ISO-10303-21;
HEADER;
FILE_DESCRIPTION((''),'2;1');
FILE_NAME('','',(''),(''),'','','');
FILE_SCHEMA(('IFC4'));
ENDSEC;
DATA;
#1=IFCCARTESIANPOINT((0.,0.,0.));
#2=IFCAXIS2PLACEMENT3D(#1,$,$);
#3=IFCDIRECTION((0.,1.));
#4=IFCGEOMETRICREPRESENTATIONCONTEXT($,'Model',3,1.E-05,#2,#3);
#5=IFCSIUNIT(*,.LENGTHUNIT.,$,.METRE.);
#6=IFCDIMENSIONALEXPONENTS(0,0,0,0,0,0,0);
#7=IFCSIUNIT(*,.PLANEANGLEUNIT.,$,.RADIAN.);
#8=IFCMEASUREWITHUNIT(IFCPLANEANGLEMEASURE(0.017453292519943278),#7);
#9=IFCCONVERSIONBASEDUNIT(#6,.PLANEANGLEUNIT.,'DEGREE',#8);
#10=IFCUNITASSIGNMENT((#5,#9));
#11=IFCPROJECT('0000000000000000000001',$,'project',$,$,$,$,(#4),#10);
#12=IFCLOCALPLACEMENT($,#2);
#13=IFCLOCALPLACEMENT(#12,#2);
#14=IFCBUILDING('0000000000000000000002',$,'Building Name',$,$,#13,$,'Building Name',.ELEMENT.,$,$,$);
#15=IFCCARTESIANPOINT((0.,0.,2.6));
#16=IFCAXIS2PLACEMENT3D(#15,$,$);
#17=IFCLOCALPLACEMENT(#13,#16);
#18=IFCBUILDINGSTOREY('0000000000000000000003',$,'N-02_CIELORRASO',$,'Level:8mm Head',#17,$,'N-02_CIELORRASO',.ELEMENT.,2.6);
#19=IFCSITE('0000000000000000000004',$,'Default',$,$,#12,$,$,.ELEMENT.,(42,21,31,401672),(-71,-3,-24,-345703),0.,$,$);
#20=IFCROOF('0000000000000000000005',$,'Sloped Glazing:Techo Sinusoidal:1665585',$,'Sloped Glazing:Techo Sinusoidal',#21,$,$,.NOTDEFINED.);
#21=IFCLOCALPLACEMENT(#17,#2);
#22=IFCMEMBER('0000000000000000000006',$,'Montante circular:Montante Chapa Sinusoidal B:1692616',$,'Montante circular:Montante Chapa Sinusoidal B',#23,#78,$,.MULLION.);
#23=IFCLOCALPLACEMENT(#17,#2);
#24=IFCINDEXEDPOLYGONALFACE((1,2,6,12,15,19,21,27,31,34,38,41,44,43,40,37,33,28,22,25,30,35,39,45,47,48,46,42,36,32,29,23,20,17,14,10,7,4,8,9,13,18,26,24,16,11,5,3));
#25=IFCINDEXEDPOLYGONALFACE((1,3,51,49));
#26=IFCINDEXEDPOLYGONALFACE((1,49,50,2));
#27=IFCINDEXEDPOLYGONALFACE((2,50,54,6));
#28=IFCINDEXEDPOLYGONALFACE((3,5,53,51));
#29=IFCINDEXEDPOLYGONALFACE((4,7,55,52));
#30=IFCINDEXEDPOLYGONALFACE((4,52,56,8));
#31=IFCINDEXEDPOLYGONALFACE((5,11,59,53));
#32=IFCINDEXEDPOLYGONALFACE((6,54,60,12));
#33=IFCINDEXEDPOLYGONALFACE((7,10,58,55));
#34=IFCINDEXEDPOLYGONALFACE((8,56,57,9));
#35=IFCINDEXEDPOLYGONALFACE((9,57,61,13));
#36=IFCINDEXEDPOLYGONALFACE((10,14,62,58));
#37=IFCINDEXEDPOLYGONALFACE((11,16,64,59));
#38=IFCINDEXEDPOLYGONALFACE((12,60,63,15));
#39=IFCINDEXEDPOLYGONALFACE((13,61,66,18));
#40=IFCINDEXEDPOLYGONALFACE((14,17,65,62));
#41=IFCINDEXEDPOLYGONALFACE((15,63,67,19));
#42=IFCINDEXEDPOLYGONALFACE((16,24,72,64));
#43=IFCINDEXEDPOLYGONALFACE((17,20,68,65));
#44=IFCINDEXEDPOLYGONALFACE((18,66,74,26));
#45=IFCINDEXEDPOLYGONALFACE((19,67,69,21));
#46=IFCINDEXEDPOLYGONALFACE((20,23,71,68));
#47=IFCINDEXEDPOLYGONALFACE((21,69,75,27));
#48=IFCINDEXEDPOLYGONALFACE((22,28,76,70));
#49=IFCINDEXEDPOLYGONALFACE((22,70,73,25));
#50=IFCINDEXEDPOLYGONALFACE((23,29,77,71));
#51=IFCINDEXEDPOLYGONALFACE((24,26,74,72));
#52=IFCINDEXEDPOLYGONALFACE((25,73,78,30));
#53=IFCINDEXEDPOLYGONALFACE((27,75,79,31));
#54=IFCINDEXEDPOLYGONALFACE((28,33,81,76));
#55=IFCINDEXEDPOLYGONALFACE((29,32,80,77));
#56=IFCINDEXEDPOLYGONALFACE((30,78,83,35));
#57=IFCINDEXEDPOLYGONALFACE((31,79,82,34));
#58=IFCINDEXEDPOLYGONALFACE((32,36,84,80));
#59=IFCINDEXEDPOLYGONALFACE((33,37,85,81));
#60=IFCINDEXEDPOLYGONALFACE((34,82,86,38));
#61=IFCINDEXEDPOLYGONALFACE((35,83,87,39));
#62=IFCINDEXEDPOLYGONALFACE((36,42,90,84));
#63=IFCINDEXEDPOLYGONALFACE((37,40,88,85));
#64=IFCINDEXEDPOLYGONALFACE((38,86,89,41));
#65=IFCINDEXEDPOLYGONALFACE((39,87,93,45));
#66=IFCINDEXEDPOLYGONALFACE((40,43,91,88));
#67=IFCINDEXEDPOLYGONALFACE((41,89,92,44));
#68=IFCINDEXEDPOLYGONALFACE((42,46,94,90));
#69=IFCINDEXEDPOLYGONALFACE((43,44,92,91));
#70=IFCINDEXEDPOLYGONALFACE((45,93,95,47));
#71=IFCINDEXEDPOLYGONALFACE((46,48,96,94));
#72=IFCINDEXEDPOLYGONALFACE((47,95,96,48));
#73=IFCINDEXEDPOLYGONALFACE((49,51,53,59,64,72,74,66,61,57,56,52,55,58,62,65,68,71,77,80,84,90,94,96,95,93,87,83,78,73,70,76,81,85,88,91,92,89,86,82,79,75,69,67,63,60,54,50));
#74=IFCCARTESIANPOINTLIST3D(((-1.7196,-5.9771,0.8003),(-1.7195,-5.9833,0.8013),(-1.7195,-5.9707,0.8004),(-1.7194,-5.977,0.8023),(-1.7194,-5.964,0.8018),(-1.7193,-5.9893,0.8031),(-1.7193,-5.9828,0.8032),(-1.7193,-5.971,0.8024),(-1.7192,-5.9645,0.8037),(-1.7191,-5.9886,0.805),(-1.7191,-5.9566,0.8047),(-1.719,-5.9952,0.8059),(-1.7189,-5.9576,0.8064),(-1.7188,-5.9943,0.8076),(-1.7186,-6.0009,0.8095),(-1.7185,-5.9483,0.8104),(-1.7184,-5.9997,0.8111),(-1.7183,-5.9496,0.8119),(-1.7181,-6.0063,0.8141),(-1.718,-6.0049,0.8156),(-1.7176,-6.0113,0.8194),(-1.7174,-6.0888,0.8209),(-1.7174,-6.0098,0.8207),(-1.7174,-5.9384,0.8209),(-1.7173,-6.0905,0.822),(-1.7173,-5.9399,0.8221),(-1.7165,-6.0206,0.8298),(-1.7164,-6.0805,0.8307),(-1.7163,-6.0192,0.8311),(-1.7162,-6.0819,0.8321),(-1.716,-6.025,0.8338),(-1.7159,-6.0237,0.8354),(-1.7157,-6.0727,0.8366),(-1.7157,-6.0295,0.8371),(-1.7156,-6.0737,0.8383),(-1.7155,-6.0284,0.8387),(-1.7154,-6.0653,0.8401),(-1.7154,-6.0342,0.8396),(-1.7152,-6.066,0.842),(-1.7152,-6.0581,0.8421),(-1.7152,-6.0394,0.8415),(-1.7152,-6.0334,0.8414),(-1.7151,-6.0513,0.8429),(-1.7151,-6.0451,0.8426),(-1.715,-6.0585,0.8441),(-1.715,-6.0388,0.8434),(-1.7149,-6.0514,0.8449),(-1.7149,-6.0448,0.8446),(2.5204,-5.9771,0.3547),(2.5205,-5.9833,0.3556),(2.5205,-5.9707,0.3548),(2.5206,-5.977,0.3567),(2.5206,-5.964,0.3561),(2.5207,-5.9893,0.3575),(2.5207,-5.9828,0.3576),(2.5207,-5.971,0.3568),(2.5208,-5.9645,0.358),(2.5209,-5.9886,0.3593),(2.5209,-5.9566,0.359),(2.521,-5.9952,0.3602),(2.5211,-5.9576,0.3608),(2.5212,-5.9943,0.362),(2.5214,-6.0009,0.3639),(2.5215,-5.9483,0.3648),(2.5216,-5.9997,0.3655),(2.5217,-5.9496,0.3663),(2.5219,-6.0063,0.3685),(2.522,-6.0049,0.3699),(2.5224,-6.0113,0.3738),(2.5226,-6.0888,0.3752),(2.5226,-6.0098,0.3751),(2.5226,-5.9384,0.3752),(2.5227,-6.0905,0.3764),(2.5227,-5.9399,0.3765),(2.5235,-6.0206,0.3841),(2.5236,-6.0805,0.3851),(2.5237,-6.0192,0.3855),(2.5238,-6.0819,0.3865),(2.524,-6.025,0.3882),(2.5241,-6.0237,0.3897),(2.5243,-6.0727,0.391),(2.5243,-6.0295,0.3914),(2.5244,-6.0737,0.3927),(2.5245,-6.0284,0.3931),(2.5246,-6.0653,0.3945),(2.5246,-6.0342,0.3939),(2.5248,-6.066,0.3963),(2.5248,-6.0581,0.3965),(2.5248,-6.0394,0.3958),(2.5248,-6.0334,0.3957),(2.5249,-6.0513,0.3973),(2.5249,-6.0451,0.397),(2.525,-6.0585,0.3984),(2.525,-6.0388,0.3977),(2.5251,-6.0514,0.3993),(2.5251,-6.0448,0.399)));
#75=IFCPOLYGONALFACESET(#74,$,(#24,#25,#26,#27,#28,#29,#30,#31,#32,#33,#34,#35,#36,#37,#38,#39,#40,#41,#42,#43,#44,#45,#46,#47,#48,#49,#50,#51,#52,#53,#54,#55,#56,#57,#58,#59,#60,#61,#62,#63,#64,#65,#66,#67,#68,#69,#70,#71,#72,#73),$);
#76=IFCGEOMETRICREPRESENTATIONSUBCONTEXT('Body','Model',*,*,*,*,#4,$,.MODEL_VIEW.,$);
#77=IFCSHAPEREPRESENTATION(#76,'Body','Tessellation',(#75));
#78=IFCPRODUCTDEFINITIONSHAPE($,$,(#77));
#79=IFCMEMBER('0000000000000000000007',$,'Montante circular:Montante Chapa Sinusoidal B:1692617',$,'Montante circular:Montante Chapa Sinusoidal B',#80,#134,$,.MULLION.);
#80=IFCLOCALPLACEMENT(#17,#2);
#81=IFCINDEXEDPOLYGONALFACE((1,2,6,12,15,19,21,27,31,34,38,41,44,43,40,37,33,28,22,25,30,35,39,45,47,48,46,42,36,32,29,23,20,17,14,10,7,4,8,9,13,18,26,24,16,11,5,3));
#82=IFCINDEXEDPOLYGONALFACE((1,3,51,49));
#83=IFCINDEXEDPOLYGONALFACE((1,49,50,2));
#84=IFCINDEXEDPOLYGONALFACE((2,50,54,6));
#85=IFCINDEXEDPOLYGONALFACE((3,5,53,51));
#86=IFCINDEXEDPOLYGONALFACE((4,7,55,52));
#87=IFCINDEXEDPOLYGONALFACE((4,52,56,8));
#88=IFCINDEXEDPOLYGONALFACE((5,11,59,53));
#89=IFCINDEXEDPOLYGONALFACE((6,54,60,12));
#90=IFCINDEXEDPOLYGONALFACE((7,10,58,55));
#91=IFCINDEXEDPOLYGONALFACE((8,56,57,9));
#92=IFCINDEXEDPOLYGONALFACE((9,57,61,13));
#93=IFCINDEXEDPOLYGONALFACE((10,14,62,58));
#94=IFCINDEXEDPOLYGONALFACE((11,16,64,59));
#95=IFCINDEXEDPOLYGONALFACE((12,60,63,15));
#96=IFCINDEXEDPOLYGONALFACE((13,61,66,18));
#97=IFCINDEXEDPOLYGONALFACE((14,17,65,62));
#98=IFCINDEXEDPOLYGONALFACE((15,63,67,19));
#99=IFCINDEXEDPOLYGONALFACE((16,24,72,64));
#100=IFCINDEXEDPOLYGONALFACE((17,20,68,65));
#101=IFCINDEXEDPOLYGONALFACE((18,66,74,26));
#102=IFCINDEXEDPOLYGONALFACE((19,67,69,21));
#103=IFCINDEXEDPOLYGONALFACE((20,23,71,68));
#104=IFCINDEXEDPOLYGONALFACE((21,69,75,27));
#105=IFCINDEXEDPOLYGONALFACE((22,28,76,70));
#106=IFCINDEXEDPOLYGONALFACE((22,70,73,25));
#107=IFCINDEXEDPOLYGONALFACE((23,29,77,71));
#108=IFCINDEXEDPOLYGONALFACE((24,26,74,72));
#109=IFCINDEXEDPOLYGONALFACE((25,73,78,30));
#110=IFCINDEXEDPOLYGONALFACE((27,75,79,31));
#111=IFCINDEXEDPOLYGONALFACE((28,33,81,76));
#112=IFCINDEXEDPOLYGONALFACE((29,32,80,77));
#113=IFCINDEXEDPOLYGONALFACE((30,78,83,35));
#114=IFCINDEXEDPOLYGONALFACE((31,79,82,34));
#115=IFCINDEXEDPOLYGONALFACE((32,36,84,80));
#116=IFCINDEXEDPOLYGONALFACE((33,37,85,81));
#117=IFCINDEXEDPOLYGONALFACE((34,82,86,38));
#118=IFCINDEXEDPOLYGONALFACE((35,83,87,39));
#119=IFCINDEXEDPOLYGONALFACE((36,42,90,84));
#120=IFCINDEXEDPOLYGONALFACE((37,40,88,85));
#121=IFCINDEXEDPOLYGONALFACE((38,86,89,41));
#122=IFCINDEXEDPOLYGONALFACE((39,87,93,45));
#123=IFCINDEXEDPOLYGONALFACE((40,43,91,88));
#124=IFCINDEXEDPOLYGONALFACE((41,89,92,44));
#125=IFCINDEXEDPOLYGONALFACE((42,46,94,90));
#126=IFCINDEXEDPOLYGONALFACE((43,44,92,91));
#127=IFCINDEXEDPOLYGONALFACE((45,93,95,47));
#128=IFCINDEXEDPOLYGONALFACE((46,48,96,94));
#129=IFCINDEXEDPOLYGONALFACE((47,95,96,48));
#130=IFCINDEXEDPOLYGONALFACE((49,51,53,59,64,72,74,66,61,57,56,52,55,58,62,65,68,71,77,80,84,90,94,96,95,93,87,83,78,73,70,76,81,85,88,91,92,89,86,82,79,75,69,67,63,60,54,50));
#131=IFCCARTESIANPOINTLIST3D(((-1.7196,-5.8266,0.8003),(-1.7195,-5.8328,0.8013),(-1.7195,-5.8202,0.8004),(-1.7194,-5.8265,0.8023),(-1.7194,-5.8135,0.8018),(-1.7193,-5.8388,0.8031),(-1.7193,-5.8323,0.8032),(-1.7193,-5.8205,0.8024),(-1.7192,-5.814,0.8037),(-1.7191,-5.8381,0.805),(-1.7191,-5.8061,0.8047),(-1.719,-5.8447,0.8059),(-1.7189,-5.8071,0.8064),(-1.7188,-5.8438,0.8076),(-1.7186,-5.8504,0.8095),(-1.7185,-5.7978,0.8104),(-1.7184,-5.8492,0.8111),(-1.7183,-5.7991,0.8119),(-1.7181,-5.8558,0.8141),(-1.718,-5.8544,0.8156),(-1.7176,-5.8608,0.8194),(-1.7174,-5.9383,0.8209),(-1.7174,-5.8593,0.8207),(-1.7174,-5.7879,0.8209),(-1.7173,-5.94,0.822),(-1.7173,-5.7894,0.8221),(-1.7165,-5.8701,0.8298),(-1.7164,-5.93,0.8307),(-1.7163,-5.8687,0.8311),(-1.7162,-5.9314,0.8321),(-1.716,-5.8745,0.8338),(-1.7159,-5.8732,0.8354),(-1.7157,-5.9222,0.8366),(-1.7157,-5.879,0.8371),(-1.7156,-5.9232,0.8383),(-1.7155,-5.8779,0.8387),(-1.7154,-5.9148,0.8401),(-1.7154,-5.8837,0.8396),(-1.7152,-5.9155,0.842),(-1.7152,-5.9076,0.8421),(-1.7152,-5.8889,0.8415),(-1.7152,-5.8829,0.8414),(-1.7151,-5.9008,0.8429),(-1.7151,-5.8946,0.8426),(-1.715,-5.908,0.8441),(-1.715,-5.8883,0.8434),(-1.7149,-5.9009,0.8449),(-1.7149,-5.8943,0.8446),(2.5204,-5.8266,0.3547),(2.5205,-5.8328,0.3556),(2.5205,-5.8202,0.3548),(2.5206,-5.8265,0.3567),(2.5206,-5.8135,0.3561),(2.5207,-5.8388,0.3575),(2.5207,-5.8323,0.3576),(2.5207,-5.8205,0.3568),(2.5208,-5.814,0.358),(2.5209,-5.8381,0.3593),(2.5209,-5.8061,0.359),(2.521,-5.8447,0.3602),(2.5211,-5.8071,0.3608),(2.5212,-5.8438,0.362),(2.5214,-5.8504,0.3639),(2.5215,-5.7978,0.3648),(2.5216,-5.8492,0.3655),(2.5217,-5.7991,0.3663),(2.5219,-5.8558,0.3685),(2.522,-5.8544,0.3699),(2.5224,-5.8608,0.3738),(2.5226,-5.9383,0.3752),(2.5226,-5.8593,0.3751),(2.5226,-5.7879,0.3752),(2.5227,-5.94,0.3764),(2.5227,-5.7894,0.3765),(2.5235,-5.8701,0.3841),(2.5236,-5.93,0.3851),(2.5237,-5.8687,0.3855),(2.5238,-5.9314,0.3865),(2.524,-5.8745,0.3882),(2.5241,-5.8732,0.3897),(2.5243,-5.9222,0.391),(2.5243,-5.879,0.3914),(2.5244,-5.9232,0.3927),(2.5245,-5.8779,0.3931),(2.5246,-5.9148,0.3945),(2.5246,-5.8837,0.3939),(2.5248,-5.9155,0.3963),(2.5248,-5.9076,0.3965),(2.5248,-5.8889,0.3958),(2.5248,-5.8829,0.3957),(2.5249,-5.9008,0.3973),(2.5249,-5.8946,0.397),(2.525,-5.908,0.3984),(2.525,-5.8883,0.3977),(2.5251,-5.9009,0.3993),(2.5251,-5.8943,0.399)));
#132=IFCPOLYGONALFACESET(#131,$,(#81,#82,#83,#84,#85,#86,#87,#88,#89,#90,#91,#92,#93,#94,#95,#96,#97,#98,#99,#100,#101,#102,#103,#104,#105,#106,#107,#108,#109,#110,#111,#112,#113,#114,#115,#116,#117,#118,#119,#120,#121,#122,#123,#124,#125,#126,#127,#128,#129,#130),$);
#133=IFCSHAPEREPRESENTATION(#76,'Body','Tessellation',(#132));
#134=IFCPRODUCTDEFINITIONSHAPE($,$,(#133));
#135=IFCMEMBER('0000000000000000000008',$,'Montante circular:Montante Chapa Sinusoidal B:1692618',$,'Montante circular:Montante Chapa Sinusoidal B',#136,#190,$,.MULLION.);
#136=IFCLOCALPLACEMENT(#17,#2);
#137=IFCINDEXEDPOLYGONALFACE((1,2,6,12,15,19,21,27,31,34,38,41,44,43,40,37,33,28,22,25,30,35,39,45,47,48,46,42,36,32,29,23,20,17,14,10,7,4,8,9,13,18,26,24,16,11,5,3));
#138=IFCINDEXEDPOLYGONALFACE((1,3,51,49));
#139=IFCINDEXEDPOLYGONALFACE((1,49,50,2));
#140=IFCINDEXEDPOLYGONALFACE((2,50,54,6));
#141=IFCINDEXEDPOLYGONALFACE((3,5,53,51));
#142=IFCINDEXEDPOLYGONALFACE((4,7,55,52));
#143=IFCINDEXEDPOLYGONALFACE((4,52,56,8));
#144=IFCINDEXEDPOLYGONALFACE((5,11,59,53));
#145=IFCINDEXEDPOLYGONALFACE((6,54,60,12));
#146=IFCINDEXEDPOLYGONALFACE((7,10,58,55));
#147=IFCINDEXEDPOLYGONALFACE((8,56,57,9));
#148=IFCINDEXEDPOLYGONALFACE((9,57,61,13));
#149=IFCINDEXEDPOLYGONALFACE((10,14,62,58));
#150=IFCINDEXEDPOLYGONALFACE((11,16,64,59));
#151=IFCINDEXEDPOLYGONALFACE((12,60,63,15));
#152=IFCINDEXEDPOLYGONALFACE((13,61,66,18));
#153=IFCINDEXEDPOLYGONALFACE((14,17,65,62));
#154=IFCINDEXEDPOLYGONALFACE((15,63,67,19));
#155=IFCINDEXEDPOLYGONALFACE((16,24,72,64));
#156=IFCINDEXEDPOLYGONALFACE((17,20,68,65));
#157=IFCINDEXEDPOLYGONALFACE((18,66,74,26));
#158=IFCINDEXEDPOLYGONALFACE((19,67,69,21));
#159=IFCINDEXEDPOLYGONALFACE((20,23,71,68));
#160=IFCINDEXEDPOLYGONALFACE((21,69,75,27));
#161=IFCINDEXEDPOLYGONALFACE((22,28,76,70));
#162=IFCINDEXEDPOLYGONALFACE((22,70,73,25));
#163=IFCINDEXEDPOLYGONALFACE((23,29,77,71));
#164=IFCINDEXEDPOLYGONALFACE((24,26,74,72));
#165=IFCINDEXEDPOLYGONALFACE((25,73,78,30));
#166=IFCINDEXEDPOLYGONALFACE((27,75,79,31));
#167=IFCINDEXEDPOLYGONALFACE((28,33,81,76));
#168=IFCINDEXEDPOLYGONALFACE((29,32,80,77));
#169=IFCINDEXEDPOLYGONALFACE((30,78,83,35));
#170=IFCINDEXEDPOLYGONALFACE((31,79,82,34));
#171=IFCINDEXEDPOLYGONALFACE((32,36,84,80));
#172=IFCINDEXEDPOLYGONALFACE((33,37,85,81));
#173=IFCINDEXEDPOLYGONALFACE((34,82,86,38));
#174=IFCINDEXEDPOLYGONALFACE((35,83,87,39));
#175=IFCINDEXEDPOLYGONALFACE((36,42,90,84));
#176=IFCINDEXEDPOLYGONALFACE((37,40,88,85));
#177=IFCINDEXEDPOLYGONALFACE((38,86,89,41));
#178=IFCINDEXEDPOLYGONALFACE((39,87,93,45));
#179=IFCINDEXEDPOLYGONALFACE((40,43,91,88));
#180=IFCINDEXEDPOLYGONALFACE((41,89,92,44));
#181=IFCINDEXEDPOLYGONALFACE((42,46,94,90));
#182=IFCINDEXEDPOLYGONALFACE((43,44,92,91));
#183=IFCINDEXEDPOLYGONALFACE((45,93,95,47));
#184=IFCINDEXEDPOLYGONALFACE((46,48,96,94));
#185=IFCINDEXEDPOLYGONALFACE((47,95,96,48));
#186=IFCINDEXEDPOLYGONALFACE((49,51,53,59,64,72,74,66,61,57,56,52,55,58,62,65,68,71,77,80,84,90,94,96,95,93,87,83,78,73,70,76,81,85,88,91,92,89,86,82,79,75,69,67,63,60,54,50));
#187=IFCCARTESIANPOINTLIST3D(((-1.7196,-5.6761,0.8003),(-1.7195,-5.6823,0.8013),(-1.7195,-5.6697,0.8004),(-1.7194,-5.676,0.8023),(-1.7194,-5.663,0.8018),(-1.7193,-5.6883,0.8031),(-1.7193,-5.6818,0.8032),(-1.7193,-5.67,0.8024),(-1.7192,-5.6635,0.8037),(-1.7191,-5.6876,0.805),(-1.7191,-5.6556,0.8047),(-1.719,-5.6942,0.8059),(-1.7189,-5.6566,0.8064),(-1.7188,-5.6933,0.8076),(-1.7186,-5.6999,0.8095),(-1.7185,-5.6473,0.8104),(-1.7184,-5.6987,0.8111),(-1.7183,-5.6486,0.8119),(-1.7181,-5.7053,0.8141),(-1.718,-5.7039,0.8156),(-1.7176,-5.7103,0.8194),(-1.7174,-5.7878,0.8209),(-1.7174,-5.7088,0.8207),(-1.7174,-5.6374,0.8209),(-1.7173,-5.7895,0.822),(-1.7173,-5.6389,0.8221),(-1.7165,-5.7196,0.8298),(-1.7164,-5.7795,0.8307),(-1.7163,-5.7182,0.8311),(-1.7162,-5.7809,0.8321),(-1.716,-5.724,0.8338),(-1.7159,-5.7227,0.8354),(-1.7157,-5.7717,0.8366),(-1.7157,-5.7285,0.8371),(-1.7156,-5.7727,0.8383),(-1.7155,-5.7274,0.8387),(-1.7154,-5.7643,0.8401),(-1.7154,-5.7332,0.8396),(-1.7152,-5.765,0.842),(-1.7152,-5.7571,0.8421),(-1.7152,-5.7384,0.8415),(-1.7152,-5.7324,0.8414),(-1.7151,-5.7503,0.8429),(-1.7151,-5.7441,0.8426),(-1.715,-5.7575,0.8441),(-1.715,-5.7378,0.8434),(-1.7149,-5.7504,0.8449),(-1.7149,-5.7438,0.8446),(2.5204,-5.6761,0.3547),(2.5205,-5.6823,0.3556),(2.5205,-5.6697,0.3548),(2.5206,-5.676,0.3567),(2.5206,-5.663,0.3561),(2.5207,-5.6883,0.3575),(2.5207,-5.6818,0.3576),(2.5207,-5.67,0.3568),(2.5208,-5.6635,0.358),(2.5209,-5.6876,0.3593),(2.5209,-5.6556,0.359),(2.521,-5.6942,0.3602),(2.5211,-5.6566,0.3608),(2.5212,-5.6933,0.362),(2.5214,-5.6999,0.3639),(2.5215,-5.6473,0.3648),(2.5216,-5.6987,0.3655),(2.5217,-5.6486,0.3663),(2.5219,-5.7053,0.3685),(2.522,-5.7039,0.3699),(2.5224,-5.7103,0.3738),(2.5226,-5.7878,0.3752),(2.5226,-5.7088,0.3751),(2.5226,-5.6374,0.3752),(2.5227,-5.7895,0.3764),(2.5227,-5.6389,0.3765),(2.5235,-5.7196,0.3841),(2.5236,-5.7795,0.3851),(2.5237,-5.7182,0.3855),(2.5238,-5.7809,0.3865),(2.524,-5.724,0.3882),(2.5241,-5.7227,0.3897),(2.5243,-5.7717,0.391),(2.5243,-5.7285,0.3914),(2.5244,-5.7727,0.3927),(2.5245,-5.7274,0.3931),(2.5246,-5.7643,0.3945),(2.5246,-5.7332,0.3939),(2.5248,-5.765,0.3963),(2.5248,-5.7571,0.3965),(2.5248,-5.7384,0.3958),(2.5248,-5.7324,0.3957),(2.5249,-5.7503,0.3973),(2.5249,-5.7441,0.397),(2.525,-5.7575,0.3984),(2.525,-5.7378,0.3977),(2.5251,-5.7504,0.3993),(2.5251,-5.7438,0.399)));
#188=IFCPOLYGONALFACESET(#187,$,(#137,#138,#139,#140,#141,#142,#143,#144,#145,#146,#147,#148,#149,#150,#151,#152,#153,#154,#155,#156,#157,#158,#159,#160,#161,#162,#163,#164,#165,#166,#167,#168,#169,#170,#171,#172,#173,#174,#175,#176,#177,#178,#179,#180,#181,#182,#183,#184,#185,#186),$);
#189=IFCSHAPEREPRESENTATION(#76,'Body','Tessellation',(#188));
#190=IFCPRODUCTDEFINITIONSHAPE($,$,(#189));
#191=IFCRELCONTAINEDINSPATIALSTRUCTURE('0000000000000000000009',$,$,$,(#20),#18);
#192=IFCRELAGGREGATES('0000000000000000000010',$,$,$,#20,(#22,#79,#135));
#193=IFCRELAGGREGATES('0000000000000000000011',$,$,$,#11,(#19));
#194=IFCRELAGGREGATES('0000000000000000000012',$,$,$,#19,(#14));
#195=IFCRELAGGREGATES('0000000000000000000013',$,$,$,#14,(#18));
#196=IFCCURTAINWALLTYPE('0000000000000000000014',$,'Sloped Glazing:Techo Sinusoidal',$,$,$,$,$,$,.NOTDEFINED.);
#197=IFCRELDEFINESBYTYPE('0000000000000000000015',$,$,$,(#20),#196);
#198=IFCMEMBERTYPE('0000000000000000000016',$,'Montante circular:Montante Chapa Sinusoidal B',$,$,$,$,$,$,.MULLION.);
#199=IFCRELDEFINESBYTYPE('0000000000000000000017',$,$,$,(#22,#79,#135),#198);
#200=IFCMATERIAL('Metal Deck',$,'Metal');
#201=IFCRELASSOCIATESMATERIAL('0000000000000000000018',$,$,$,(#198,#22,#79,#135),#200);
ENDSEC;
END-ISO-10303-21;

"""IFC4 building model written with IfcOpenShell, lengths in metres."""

from ifc_helpers import new_model, entity, si_unit, converted_unit, direction, frame, origin, place, context, subcontext, project, spatial, indexed_curve, outline, extrude, source, transform, mapped, material, type_object, type_shapes, element, aggregate, save


model = new_model("IFC4")

# Units and contexts
model_context = context("Model", 3, precision=1e-05, world=origin(), true_north=direction((0.0, 1.0)))
body_context = subcontext(model_context, "Body", "Model", "MODEL_VIEW")
ifc_project = project(units=[si_unit("LENGTHUNIT", "METRE"), converted_unit("PLANEANGLEUNIT", "DEGREE", entity("IfcPlaneAngleMeasure", 0.017453292519943278), si_unit("PLANEANGLEUNIT", "RADIAN"), dimensions=[0, 0, 0, 0, 0, 0, 0])], contexts=[model_context])

# Site, building, storey
site_placement = place(None, origin())
site = spatial("IfcSite", under=ifc_project, at=site_placement, Name="Default", CompositionType="ELEMENT", RefLatitude=(42, 21, 31, 401672), RefLongitude=(-71, -3, -24, -345703), RefElevation=0.0)
building_placement = place(site_placement, origin())
building = spatial("IfcBuilding", under=site, at=building_placement, Name="Building Name", LongName="Building Name", CompositionType="ELEMENT")
storey_placement = place(building_placement, frame((0.0, 0.0, 2.6)))
storey = spatial("IfcBuildingStorey", under=building, at=storey_placement, Name="N-02_CIELORRASO", ObjectType="Level:8mm Head", LongName="N-02_CIELORRASO", CompositionType="ELEMENT", Elevation=2.6)

# Roof, members
curtain_wall_type = type_object("IfcCurtainWallType", Name="Sloped Glazing:Techo Sinusoidal", PredefinedType="NOTDEFINED")
roof_1_placement = place(storey_placement, frame((0.0, 0.0, -2.6)))
roof_1 = element("IfcRoof", 1, at=roof_1_placement, inside=storey, type_object=curtain_wall_type, Name="Sloped Glazing:Techo Sinusoidal:1665585", ObjectType="Sloped Glazing:Techo Sinusoidal", PredefinedType="NOTDEFINED")
ifc_material = material(Name="Metal Deck", Category="Metal")
member_type_1 = type_object("IfcMemberType", Name="Montante circular:Montante Chapa Sinusoidal B", PredefinedType="MULLION", material=ifc_material)
shared_shape_1 = source(origin(), body_context, "Body", "SweptSolid", [
    extrude(outline(indexed_curve([(0.0595, -0.0443), (0.0615, -0.0443), (0.0603, -0.031), (0.0572, -0.0213), (0.053, -0.0138), (0.0481, -0.0078), (0.0427, -0.003), (0.0372, 0.0005), (0.0315, 0.0029), (0.0259, 0.0044), (0.0203, 0.0051), (0.0146, 0.005), (0.0084, 0.0041), (-0.0053, 0.0009), (-0.0123, -0.0005), (-0.0191, -0.0012), (-0.0256, -0.001), (-0.0317, 0.0001), (-0.0375, 0.0019), (-0.0428, 0.0046), (-0.0477, 0.0081), (-0.0522, 0.0128), (-0.0563, 0.0191), (-0.0597, 0.0282), (-0.0617, 0.0421), (-0.0637, 0.042), (-0.0616, 0.0277), (-0.0581, 0.0182), (-0.0537, 0.0116), (-0.049, 0.0066), (-0.0438, 0.0028), (-0.0382, 0.0001), (-0.0322, -0.0019), (-0.0258, -0.003), (-0.019, -0.0032), (-0.012, -0.0025), (-0.0048, -0.0011), (0.0088, 0.0021), (0.0147, 0.003), (0.0202, 0.0031), (0.0255, 0.0024), (0.0309, 0.001), (0.0362, -0.0013), (0.0415, -0.0046), (0.0466, -0.0092), (0.0513, -0.0149), (0.0554, -0.0221), (0.0584, -0.0314), (0.0595, -0.0443)], self_intersect=False)), frame((-0.007, 0.0228, -4.2634), z_axis=(0.0, 0.0, 1.0), x_axis=(-0.819152, -0.573576, 0.0)), (0.0, 0.0, 1.0), 4.2634),
])
type_shapes(member_type_1, [shared_shape_1])
member_1_placement = place(roof_1_placement, frame((-1.7148, -6.0076, 3.4456), z_axis=(-0.994522, 0.0, 0.104528), x_axis=(0.0, 1.0, 0.0)))
member_1 = element("IfcMember", 2, at=member_1_placement, type_object=member_type_1, material=ifc_material, Name="Montante circular:Montante Chapa Sinusoidal B:1692616", ObjectType="Montante circular:Montante Chapa Sinusoidal B", PredefinedType="MULLION", context=body_context, shape_type="MappedRepresentation", body=[
    mapped(shared_shape_1, transform((0.0, 0.0, 0.0), scale=1.0)),
])
member_2_placement = place(roof_1_placement, frame((-1.7148, -5.8571, 3.4456), z_axis=(-0.994522, 0.0, 0.104528), x_axis=(0.0, 1.0, 0.0)))
member_2 = element("IfcMember", 3, at=member_2_placement, type_object=member_type_1, material=ifc_material, Name="Montante circular:Montante Chapa Sinusoidal B:1692617", ObjectType="Montante circular:Montante Chapa Sinusoidal B", PredefinedType="MULLION", context=body_context, shape_type="MappedRepresentation", body=[
    mapped(shared_shape_1, transform((0.0, 0.0, 0.0), scale=1.0)),
])
member_3_placement = place(roof_1_placement, frame((-1.7148, -5.7066, 3.4456), z_axis=(-0.994522, 0.0, 0.104528), x_axis=(0.0, 1.0, 0.0)))
member_3 = element("IfcMember", 4, at=member_3_placement, type_object=member_type_1, material=ifc_material, Name="Montante circular:Montante Chapa Sinusoidal B:1692618", ObjectType="Montante circular:Montante Chapa Sinusoidal B", PredefinedType="MULLION", context=body_context, shape_type="MappedRepresentation", body=[
    mapped(shared_shape_1, transform((0.0, 0.0, 0.0), scale=1.0)),
])
aggregate(roof_1, [member_1, member_2, member_3])

save(model, "model.ifc")
